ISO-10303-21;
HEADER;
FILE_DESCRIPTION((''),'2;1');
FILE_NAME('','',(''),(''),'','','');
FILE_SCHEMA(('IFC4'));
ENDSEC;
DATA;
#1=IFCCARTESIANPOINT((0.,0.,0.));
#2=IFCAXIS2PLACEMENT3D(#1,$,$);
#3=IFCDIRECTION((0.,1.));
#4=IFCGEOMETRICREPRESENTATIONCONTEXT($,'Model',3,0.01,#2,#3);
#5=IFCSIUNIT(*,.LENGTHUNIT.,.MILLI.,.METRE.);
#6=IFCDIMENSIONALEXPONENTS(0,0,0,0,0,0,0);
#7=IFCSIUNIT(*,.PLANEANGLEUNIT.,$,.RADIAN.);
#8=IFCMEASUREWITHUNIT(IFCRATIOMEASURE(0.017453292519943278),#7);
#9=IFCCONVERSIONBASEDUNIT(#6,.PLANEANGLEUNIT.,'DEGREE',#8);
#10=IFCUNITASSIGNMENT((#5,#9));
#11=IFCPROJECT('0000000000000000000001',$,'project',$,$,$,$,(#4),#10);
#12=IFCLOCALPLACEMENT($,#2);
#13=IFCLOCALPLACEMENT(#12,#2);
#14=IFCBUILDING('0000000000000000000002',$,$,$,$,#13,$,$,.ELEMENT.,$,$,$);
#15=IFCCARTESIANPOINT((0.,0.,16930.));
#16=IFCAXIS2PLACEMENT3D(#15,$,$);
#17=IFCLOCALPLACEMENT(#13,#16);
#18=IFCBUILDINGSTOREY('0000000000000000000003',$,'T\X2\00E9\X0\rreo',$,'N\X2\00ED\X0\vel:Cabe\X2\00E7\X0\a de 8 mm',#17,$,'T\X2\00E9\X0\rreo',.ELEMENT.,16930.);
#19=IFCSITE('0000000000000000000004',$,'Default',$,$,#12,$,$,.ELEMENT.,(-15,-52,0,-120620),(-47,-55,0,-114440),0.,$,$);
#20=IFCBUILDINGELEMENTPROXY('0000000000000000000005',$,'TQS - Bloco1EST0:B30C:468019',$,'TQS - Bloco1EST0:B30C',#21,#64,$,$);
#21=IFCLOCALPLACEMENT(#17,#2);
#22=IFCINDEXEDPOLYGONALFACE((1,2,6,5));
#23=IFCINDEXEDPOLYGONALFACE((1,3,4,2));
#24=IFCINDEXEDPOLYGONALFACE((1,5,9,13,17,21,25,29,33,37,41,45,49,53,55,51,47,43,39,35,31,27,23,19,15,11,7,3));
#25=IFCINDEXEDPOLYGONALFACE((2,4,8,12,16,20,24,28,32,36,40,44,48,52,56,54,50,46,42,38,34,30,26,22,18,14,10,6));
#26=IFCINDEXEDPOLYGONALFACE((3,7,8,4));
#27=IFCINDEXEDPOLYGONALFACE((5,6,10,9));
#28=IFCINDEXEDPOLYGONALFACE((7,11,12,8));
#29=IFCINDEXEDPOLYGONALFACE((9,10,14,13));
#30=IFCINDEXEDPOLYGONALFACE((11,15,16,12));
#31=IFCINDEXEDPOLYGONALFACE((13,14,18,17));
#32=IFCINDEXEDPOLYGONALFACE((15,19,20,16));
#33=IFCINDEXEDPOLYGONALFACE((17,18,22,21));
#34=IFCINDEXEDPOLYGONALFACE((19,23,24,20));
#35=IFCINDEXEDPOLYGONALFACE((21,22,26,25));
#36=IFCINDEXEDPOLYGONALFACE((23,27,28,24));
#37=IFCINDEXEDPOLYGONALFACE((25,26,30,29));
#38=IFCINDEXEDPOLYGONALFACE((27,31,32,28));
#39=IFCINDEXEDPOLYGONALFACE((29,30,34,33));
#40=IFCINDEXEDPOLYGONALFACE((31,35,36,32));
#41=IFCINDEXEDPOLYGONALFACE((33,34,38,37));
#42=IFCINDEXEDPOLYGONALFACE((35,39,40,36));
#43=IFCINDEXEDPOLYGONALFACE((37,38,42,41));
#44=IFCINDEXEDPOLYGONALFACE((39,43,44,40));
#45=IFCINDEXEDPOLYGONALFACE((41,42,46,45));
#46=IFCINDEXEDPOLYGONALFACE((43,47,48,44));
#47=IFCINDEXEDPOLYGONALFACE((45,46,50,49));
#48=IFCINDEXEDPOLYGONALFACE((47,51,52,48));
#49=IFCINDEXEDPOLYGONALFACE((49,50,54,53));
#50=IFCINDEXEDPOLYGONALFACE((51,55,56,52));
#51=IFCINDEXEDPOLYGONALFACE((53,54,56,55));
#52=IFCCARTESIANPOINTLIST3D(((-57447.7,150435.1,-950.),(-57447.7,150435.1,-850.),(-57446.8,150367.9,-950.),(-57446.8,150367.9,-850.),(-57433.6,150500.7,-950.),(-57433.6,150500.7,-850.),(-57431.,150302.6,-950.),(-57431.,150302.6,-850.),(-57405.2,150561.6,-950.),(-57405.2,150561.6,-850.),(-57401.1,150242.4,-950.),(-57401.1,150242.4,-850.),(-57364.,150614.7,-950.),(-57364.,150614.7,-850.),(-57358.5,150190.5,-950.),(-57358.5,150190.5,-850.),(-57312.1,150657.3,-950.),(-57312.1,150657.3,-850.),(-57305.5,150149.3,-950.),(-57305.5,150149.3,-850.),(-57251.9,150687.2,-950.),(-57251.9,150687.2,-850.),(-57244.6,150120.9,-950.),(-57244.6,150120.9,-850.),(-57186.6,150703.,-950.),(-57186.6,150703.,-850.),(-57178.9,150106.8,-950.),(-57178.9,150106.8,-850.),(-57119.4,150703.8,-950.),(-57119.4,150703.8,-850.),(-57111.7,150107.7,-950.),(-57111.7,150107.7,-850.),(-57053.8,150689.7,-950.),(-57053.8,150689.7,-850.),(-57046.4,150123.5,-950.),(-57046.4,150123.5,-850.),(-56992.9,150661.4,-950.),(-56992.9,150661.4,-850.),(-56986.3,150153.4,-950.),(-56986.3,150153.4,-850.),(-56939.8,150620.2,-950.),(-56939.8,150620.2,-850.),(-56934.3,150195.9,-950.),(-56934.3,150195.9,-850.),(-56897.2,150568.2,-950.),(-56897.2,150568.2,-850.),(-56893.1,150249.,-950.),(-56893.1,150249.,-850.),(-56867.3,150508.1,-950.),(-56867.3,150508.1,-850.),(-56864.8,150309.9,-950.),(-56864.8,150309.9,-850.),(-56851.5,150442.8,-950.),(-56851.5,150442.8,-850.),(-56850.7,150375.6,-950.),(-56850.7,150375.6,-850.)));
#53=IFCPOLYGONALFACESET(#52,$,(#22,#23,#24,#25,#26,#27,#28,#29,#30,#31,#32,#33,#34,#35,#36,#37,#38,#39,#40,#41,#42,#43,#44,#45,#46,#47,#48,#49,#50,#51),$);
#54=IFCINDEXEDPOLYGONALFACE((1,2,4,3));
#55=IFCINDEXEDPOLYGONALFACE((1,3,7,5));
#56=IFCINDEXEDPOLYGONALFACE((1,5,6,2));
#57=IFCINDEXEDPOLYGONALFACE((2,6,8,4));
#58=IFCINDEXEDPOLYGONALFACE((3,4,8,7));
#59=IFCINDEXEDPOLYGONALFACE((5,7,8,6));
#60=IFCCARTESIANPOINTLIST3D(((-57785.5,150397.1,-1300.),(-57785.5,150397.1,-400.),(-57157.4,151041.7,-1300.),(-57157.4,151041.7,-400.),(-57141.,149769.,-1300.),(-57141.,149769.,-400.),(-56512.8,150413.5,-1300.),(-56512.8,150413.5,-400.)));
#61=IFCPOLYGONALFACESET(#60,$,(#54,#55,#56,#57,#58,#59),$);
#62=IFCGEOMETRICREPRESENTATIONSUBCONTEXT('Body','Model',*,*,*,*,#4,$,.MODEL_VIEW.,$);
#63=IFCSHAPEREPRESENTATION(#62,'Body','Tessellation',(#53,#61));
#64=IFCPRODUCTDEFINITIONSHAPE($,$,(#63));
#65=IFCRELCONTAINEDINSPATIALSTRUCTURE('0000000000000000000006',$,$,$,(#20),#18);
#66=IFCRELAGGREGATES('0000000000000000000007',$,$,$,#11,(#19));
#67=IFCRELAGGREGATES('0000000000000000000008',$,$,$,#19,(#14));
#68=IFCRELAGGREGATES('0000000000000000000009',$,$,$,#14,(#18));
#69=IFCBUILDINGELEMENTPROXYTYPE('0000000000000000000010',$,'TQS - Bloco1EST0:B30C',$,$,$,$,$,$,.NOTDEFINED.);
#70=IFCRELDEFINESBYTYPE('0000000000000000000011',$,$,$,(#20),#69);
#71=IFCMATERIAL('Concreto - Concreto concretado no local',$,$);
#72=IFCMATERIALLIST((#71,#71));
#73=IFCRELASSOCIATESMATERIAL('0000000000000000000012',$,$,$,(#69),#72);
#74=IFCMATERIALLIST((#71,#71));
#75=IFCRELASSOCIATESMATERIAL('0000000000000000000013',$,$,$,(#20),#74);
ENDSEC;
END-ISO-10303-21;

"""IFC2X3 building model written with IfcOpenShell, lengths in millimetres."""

from ifc_helpers import new_model, entity, si_unit, converted_unit, direction, frame, frame_2d, origin, origin_2d_with_axis, place, context, subcontext, project, spatial, rectangle, circle, extrude, source, transform, mapped, material, material_list, type_object, type_shapes, element, save


model = new_model("IFC2X3")

# Units and contexts
model_context = context("Model", 3, precision=0.01, world=origin(), true_north=direction((0.0, 1.0)))
body_context = subcontext(model_context, "Body", "Model", "MODEL_VIEW")
ifc_project = project(units=[si_unit("LENGTHUNIT", "METRE", prefix="MILLI"), converted_unit("PLANEANGLEUNIT", "DEGREE", entity("IfcRatioMeasure", 0.017453292519943278), si_unit("PLANEANGLEUNIT", "RADIAN"), dimensions=[0, 0, 0, 0, 0, 0, 0])], contexts=[model_context])

# Site, building, storey
site_placement = place(None, origin())
site = spatial("IfcSite", under=ifc_project, at=site_placement, Name="Default", CompositionType="ELEMENT", RefLatitude=(-15, -52, 0, -120620), RefLongitude=(-47, -55, 0, -114440), RefElevation=0.0)
building_placement = place(site_placement, origin())
building = spatial("IfcBuilding", under=site, at=building_placement, CompositionType="ELEMENT")
storey_placement = place(building_placement, frame((0.0, 0.0, 16930.0)))
storey = spatial("IfcBuildingStorey", under=building, at=storey_placement, Name="Térreo", ObjectType="Nível:Cabeça de 8 mm", LongName="Térreo", CompositionType="ELEMENT", Elevation=16930.0)

# Building element proxy
ifc_material_1 = material(Name="Concreto - Concreto concretado no local")
ifc_material_list_1 = material_list([ifc_material_1, ifc_material_1])
ifc_material_list_2 = material_list([ifc_material_1, ifc_material_1])
building_element_proxy_type_1 = type_object("IfcBuildingElementProxyType", Name="TQS - Bloco1EST0:B30C", PredefinedType="NOTDEFINED", material=ifc_material_list_2)
shared_shape_1 = source(origin(), body_context, "Body", "SweptSolid", [
    extrude(circle(Radius=300.0, at=frame_2d((0.0, 0.0), x_axis=(1.0, 0.0))), frame((0.0, 0.0, -550.0)), (0.0, 0.0, 1.0), 100.0),
    extrude(rectangle(XDim=900.0, YDim=900.0, at=origin_2d_with_axis()), frame((0.0, 0.0, -900.0), z_axis=(0.0, 0.0, 1.0), x_axis=(-1.0, 0.0, 0.0)), (0.0, 0.0, 1.0), 900.0),
])
type_shapes(building_element_proxy_type_1, [shared_shape_1])
proxy_1_placement = place(storey_placement, frame((-57149.2, 150405.3, -400.0), z_axis=(0.0, 0.0, 1.0), x_axis=(0.697915, 0.71618, 0.0)))
element("IfcBuildingElementProxy", 1, at=proxy_1_placement, inside=storey, type_object=building_element_proxy_type_1, material=ifc_material_list_1, Name="TQS - Bloco1EST0:B30C:468019", ObjectType="TQS - Bloco1EST0:B30C", context=body_context, shape_type="MappedRepresentation", body=[
    mapped(shared_shape_1, transform((0.0, 0.0, 0.0), scale=1.0)),
])

save(model, "model.ifc")
